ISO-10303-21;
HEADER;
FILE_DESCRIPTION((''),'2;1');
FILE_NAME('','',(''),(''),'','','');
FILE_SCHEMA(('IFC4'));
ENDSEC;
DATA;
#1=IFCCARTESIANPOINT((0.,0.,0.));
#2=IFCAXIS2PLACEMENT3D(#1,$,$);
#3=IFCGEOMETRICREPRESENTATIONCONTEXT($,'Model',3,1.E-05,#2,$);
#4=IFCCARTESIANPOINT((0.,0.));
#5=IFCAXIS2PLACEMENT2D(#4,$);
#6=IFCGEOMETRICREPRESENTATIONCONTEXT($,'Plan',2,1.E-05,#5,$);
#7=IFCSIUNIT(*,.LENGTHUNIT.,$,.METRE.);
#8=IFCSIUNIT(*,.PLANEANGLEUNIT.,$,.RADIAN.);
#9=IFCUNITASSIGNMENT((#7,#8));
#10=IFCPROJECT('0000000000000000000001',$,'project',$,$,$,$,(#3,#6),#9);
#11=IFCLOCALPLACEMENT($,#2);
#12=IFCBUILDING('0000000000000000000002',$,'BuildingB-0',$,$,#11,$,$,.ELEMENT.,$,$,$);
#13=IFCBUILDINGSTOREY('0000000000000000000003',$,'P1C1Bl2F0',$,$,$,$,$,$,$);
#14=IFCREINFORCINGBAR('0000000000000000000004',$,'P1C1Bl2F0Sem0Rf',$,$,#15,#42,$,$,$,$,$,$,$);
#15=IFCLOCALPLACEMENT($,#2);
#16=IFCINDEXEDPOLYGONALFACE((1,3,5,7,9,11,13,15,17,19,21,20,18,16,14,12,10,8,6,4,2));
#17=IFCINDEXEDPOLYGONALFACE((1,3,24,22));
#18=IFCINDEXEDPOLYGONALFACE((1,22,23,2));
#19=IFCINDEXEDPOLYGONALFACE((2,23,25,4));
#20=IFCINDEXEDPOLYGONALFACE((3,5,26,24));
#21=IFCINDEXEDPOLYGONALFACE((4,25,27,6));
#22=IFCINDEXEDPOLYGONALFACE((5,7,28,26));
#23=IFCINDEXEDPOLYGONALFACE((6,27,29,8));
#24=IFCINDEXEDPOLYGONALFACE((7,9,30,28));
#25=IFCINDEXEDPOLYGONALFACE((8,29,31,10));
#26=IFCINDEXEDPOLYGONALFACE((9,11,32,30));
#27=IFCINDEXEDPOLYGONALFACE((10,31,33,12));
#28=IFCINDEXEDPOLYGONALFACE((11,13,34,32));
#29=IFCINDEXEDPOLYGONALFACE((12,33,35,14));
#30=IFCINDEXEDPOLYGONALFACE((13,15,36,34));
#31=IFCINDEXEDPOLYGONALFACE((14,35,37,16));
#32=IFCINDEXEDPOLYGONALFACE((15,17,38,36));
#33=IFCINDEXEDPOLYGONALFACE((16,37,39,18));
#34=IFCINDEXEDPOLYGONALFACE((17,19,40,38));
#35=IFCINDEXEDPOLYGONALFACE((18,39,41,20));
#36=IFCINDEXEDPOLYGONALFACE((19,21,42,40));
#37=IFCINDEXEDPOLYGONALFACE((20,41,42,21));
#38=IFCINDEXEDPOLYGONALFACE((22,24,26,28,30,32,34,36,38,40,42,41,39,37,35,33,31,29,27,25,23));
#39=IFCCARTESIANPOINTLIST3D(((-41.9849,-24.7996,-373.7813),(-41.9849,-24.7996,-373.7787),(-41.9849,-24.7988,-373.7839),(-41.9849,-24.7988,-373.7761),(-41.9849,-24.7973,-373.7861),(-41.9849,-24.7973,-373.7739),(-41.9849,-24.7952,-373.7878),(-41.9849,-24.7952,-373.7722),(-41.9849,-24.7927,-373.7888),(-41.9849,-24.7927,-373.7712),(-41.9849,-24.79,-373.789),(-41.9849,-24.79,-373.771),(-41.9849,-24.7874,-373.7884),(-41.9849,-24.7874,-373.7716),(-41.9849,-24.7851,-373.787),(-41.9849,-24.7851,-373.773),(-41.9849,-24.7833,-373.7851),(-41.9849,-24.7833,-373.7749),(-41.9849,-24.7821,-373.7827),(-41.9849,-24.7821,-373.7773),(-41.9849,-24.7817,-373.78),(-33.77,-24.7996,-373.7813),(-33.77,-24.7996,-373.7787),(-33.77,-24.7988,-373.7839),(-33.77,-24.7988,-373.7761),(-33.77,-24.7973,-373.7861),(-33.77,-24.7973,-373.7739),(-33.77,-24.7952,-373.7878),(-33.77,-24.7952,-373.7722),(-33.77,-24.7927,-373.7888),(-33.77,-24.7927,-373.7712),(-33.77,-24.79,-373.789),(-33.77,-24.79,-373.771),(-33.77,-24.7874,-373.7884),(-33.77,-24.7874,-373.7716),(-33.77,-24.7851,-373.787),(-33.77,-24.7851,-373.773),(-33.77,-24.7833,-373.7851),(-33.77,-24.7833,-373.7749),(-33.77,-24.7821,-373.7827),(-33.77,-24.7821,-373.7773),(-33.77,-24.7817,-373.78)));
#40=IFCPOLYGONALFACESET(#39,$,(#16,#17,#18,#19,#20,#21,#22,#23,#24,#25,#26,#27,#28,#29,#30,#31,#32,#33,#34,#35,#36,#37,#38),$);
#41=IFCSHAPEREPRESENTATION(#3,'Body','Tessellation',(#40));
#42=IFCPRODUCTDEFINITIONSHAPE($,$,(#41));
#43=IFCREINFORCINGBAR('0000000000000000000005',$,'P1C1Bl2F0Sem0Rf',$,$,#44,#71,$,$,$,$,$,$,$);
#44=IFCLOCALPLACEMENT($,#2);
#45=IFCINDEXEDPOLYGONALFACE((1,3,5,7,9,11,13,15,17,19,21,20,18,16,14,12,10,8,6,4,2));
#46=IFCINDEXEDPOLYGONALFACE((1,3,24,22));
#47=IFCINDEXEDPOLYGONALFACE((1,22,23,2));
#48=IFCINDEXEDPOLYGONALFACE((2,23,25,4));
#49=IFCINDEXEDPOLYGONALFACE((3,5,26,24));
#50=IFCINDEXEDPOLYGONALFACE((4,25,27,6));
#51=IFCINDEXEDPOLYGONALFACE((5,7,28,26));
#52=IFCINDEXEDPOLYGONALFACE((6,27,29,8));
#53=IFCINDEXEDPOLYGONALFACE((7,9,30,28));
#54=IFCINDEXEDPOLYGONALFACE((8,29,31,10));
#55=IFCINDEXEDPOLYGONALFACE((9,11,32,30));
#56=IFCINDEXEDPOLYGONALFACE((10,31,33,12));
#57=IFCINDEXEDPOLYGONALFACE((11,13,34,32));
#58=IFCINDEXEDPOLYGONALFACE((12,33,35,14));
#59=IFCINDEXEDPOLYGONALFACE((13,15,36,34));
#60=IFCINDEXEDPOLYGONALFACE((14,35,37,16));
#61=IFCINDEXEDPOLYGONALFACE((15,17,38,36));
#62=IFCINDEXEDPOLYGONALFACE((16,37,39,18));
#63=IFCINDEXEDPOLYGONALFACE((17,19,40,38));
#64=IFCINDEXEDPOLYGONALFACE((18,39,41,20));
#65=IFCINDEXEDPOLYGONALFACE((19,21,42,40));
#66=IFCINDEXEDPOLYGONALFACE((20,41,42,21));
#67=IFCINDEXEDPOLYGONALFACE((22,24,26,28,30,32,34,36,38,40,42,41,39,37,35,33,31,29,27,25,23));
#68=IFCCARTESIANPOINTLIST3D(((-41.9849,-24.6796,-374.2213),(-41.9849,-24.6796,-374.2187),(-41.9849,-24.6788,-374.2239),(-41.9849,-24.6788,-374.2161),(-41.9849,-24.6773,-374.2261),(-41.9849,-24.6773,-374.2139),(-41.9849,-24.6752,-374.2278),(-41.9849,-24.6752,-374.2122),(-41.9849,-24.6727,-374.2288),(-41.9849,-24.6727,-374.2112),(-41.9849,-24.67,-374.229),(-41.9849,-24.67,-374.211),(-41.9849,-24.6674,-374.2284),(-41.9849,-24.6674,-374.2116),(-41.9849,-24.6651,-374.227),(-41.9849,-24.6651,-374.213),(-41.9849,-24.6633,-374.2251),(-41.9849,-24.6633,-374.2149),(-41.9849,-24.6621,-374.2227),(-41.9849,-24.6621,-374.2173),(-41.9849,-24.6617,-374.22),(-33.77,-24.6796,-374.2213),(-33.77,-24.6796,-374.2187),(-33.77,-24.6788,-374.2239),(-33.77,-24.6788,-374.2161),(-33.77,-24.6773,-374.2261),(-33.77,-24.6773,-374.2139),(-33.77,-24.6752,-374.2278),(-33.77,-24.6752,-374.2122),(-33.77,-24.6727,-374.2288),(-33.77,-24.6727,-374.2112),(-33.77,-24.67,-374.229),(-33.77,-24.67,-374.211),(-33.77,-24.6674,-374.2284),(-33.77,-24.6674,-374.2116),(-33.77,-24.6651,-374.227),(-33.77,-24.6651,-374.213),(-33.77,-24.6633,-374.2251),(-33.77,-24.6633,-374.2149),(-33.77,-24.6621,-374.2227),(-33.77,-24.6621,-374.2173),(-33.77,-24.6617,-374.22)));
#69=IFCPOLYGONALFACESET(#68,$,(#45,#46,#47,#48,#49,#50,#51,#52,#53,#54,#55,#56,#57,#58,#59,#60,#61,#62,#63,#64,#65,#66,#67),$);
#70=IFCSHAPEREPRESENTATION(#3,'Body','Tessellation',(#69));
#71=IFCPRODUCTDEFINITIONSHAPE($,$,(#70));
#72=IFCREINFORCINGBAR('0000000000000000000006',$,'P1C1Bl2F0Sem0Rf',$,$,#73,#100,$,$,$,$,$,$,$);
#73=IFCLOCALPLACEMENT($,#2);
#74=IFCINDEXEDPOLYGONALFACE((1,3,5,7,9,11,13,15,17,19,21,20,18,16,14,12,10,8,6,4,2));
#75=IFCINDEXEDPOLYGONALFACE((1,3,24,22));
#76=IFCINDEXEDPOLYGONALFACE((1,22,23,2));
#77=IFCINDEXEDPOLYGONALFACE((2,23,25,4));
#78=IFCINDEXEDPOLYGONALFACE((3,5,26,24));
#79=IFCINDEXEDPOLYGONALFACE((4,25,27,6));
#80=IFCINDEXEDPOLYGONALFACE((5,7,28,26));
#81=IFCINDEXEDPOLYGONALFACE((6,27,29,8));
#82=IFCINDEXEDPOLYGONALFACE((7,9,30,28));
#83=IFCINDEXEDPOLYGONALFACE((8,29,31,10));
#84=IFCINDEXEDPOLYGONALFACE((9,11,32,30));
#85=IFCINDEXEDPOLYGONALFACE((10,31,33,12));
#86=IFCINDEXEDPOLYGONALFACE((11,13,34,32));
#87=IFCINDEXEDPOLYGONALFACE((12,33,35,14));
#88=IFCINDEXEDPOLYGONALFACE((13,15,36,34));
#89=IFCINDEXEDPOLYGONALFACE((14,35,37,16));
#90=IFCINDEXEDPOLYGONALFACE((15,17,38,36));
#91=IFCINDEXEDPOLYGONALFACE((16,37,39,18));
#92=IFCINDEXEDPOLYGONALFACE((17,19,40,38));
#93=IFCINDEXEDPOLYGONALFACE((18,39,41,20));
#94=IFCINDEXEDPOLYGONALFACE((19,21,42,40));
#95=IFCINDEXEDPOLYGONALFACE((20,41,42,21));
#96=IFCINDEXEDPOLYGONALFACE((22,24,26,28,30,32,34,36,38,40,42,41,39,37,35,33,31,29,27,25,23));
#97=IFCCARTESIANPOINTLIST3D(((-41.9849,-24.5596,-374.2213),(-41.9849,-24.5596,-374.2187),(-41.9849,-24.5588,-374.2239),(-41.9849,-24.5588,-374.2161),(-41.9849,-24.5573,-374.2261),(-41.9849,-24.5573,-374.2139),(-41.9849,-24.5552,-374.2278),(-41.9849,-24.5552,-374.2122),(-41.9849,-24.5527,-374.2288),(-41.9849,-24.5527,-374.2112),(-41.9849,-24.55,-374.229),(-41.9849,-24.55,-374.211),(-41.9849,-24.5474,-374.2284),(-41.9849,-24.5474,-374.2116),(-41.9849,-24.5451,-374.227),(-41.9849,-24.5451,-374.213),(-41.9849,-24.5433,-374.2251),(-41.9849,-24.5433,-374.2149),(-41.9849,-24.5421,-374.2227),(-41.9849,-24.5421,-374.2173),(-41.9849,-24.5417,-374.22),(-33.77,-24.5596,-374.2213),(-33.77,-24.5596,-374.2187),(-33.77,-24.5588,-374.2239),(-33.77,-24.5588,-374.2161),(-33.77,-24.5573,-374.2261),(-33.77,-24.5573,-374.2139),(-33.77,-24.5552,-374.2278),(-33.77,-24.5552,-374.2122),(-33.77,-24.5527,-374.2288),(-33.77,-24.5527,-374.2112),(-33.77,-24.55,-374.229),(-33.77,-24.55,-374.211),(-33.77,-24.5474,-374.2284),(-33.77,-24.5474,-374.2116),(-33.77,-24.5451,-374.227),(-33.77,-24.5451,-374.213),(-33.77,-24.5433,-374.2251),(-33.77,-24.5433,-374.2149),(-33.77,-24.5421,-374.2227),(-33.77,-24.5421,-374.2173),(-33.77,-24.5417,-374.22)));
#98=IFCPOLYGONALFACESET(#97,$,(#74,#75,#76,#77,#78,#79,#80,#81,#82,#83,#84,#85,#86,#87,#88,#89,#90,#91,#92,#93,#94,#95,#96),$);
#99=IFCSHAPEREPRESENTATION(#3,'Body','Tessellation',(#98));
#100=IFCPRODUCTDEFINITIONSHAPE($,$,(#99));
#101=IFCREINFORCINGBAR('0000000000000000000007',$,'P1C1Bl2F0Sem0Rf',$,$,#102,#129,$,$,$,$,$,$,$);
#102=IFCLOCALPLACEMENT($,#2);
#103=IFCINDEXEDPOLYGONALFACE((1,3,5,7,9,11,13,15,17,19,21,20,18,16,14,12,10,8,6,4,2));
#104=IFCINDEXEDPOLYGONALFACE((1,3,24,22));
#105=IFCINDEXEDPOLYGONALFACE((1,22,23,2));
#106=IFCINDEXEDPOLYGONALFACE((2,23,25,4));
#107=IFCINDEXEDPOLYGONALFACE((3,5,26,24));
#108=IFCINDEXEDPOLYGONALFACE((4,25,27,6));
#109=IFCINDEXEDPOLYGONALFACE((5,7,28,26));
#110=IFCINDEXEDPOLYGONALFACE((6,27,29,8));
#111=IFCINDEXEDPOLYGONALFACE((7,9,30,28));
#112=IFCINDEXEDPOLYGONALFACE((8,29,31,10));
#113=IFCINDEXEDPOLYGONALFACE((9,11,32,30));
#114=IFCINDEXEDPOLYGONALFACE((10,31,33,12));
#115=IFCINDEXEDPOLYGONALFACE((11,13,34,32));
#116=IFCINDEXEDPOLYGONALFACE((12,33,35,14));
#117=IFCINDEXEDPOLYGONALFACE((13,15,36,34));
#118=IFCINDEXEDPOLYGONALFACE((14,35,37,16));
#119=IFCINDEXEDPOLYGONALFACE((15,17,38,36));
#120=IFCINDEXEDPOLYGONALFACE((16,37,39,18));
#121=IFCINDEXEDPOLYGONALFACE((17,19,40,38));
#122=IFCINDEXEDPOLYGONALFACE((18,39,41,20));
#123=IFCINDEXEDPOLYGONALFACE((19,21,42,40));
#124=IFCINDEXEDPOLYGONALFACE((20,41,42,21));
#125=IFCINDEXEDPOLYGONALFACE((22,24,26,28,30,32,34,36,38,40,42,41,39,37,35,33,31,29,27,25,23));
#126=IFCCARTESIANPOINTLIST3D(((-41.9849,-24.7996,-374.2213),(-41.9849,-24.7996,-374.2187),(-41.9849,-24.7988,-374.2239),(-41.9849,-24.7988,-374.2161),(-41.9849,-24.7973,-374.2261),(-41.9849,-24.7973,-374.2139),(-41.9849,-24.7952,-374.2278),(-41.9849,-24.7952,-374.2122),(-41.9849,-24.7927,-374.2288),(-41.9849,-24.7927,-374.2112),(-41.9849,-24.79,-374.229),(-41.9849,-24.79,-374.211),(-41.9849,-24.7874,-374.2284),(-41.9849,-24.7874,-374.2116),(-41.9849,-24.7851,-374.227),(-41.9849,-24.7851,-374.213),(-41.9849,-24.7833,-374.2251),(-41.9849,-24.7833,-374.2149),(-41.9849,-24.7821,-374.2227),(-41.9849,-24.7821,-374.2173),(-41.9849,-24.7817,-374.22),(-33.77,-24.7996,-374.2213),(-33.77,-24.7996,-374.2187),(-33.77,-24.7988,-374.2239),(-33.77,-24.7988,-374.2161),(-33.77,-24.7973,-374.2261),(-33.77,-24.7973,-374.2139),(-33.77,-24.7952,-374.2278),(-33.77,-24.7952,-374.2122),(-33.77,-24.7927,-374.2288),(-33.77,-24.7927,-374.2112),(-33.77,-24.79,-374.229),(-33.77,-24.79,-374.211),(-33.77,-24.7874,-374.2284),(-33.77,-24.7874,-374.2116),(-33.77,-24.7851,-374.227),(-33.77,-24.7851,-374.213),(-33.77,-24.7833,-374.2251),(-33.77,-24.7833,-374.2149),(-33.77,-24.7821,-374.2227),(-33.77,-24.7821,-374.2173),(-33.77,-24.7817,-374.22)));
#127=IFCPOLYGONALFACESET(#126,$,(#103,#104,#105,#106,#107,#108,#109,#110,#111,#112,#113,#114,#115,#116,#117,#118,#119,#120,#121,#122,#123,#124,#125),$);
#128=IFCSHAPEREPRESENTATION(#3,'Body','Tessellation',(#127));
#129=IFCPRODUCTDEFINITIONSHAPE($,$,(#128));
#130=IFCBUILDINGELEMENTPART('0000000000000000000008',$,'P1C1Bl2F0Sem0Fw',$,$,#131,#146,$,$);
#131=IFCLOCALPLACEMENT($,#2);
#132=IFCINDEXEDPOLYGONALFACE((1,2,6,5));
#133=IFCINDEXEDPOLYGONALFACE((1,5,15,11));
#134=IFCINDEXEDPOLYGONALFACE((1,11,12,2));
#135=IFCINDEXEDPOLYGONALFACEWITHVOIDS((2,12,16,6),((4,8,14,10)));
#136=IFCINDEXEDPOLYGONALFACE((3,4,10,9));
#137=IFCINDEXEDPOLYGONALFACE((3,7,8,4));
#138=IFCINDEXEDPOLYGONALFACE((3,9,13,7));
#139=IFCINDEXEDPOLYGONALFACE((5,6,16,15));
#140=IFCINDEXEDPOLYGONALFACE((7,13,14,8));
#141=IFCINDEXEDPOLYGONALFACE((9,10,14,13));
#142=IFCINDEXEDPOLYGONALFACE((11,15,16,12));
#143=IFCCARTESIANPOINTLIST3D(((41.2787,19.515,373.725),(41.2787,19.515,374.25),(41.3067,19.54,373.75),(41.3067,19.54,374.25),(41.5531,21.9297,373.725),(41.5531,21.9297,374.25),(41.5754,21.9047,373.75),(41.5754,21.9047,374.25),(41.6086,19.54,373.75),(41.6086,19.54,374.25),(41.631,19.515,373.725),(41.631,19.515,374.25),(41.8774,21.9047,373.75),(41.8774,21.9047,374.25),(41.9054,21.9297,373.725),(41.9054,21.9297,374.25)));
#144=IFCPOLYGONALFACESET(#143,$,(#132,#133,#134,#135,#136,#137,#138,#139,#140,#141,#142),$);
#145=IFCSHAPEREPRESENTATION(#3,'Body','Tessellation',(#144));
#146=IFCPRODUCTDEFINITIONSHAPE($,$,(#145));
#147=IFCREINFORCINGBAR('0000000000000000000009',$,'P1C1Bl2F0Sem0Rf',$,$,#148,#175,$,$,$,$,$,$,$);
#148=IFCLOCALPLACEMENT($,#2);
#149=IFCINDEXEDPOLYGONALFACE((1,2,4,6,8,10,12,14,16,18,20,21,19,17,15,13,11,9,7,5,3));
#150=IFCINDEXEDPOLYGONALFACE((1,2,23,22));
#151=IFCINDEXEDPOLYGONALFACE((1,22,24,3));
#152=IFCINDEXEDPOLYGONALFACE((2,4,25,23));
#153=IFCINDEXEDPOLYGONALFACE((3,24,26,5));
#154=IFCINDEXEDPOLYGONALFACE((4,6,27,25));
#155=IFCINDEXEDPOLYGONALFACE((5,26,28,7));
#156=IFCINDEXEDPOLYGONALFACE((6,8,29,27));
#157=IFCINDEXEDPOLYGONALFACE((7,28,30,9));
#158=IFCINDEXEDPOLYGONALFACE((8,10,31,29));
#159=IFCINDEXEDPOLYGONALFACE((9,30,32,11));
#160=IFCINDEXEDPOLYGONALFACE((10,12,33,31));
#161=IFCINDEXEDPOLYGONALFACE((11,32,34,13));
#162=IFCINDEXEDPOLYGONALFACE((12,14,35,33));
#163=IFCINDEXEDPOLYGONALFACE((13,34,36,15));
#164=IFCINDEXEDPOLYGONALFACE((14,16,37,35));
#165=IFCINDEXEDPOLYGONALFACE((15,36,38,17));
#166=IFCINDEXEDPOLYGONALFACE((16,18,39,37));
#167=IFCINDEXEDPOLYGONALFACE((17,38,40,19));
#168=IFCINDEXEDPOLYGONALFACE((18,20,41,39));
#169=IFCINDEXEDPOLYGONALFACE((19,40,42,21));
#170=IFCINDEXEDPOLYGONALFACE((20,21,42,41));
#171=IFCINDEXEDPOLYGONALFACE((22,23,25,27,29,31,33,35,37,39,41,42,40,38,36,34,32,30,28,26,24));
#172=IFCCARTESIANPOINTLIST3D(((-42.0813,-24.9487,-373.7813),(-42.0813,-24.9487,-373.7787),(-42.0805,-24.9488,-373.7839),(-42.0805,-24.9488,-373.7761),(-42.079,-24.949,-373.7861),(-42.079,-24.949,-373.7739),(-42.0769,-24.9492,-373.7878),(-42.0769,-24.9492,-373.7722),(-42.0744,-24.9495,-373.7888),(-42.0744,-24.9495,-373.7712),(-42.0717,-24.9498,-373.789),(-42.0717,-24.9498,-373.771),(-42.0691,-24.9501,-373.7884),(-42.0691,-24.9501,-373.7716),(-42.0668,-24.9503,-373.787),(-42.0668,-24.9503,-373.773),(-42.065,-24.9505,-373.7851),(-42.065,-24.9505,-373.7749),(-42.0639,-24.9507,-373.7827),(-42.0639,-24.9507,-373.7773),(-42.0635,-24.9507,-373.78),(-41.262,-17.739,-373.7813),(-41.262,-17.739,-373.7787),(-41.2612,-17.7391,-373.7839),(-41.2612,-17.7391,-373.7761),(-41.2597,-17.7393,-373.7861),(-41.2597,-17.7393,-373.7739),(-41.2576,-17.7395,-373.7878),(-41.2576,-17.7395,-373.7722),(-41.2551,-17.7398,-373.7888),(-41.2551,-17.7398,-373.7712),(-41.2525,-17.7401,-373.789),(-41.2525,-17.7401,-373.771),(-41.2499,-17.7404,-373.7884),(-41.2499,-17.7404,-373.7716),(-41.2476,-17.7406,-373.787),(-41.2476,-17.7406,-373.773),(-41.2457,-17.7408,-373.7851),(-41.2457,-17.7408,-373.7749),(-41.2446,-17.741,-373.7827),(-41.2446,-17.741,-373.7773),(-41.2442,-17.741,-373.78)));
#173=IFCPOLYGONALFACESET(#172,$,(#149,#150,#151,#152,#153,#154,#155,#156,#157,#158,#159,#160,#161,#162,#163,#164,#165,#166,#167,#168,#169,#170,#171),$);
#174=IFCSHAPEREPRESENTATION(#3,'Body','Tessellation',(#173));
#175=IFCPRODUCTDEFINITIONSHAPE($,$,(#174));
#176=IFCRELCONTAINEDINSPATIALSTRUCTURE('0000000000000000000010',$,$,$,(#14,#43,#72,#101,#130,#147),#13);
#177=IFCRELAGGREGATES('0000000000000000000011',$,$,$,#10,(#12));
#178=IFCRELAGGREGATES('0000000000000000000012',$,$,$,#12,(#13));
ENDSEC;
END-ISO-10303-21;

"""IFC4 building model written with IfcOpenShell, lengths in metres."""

from ifc_helpers import new_model, entity, si_unit, origin, origin_2d, place, context, project, spatial, polyline, outline, extrude, element, save


model = new_model("IFC4")

# Units and contexts
model_context = context("Model", 3, precision=1e-05, world=origin())
plan_context = context("Plan", 2, precision=1e-05, world=origin_2d())
ifc_project = project(units=[si_unit("LENGTHUNIT", "METRE"), si_unit("PLANEANGLEUNIT", "RADIAN")], contexts=[model_context, plan_context])

# Building, storey
building_placement = place(None, origin())
building = spatial("IfcBuilding", under=ifc_project, at=building_placement, Name="BuildingB-0", CompositionType="ELEMENT")
storey = spatial("IfcBuildingStorey", under=building, Name="P1C1Bl2F0")

# Reinforcing bars
element("IfcReinforcingBar", 1, inside=storey, Name="P1C1Bl2F0Sem0Rf", context=model_context, shape_type="SweptSolid", body=[
    entity("IfcSurfaceCurveSweptAreaSolid", entity("IfcCircleProfileDef", "AREA", None, None, 0.009), None, entity("IfcPolyline", [entity("IfcCartesianPoint", [33.77, 24.7907, 373.78]), entity("IfcCartesianPoint", [41.9849, 24.7907, 373.78])]), None, None, entity("IfcPlane", entity("IfcAxis2Placement3D", entity("IfcCartesianPoint", [33.77, 24.7907, 373.78]), entity("IfcDirection", [0.0, 0.0, 1.0]), entity("IfcDirection", [1.0, 0.0, 0.0])))),
])
element("IfcReinforcingBar", 2, inside=storey, Name="P1C1Bl2F0Sem0Rf", context=model_context, shape_type="SweptSolid", body=[
    entity("IfcSurfaceCurveSweptAreaSolid", entity("IfcCircleProfileDef", "AREA", None, None, 0.009), None, entity("IfcPolyline", [entity("IfcCartesianPoint", [33.77, 24.6707, 374.22]), entity("IfcCartesianPoint", [41.9849, 24.6707, 374.22])]), None, None, entity("IfcPlane", entity("IfcAxis2Placement3D", entity("IfcCartesianPoint", [33.77, 24.6707, 374.22]), entity("IfcDirection", [0.0, 0.0, 1.0]), entity("IfcDirection", [1.0, 0.0, 0.0])))),
])
element("IfcReinforcingBar", 3, inside=storey, Name="P1C1Bl2F0Sem0Rf", context=model_context, shape_type="SweptSolid", body=[
    entity("IfcSurfaceCurveSweptAreaSolid", entity("IfcCircleProfileDef", "AREA", None, None, 0.009), None, entity("IfcPolyline", [entity("IfcCartesianPoint", [33.77, 24.5507, 374.22]), entity("IfcCartesianPoint", [41.9849, 24.5507, 374.22])]), None, None, entity("IfcPlane", entity("IfcAxis2Placement3D", entity("IfcCartesianPoint", [33.77, 24.5507, 374.22]), entity("IfcDirection", [0.0, 0.0, 1.0]), entity("IfcDirection", [1.0, 0.0, 0.0])))),
])
element("IfcReinforcingBar", 4, inside=storey, Name="P1C1Bl2F0Sem0Rf", context=model_context, shape_type="SweptSolid", body=[
    entity("IfcSurfaceCurveSweptAreaSolid", entity("IfcCircleProfileDef", "AREA", None, None, 0.009), None, entity("IfcPolyline", [entity("IfcCartesianPoint", [33.77, 24.7907, 374.22]), entity("IfcCartesianPoint", [41.9849, 24.7907, 374.22])]), None, None, entity("IfcPlane", entity("IfcAxis2Placement3D", entity("IfcCartesianPoint", [33.77, 24.7907, 374.22]), entity("IfcDirection", [0.0, 0.0, 1.0]), entity("IfcDirection", [1.0, 0.0, 0.0])))),
])

# Building element part, opening
building_element_part_1 = element("IfcBuildingElementPart", 5, inside=storey, Name="P1C1Bl2F0Sem0Fw", context=model_context, shape_type="SweptSolid", body=[
    extrude(outline(polyline([(41.2787, 19.515, 373.725), (41.631, 19.515, 373.725), (41.9054, 21.9297, 373.725), (41.5531, 21.9297, 373.725), (41.2787, 19.515, 373.725)])), None, (0.0, 0.0, 1.0), 0.525),
])
element("IfcOpeningElement", 6, inside=storey, cuts=building_element_part_1, context=model_context, shape_type="SweptSolid", body=[
    extrude(outline(polyline([(41.3067, 19.54, 373.75), (41.6086, 19.54, 373.75), (41.8774, 21.9047, 373.75), (41.5754, 21.9047, 373.75), (41.3067, 19.54, 373.75)])), None, (0.0, 0.0, 1.0), 0.5),
])

# Reinforcing bar
element("IfcReinforcingBar", 7, inside=storey, Name="P1C1Bl2F0Sem0Rf", context=model_context, shape_type="SweptSolid", body=[
    entity("IfcSurfaceCurveSweptAreaSolid", entity("IfcCircleProfileDef", "AREA", None, None, 0.009), None, entity("IfcPolyline", [entity("IfcCartesianPoint", [41.2531, 17.74, 373.78]), entity("IfcCartesianPoint", [42.0724, 24.9497, 373.78])]), None, None, entity("IfcPlane", entity("IfcAxis2Placement3D", entity("IfcCartesianPoint", [41.2531, 17.74, 373.78]), entity("IfcDirection", [0.0, 0.0, 1.0]), entity("IfcDirection", [1.0, 0.0, 0.0])))),
])

save(model, "model.ifc")
